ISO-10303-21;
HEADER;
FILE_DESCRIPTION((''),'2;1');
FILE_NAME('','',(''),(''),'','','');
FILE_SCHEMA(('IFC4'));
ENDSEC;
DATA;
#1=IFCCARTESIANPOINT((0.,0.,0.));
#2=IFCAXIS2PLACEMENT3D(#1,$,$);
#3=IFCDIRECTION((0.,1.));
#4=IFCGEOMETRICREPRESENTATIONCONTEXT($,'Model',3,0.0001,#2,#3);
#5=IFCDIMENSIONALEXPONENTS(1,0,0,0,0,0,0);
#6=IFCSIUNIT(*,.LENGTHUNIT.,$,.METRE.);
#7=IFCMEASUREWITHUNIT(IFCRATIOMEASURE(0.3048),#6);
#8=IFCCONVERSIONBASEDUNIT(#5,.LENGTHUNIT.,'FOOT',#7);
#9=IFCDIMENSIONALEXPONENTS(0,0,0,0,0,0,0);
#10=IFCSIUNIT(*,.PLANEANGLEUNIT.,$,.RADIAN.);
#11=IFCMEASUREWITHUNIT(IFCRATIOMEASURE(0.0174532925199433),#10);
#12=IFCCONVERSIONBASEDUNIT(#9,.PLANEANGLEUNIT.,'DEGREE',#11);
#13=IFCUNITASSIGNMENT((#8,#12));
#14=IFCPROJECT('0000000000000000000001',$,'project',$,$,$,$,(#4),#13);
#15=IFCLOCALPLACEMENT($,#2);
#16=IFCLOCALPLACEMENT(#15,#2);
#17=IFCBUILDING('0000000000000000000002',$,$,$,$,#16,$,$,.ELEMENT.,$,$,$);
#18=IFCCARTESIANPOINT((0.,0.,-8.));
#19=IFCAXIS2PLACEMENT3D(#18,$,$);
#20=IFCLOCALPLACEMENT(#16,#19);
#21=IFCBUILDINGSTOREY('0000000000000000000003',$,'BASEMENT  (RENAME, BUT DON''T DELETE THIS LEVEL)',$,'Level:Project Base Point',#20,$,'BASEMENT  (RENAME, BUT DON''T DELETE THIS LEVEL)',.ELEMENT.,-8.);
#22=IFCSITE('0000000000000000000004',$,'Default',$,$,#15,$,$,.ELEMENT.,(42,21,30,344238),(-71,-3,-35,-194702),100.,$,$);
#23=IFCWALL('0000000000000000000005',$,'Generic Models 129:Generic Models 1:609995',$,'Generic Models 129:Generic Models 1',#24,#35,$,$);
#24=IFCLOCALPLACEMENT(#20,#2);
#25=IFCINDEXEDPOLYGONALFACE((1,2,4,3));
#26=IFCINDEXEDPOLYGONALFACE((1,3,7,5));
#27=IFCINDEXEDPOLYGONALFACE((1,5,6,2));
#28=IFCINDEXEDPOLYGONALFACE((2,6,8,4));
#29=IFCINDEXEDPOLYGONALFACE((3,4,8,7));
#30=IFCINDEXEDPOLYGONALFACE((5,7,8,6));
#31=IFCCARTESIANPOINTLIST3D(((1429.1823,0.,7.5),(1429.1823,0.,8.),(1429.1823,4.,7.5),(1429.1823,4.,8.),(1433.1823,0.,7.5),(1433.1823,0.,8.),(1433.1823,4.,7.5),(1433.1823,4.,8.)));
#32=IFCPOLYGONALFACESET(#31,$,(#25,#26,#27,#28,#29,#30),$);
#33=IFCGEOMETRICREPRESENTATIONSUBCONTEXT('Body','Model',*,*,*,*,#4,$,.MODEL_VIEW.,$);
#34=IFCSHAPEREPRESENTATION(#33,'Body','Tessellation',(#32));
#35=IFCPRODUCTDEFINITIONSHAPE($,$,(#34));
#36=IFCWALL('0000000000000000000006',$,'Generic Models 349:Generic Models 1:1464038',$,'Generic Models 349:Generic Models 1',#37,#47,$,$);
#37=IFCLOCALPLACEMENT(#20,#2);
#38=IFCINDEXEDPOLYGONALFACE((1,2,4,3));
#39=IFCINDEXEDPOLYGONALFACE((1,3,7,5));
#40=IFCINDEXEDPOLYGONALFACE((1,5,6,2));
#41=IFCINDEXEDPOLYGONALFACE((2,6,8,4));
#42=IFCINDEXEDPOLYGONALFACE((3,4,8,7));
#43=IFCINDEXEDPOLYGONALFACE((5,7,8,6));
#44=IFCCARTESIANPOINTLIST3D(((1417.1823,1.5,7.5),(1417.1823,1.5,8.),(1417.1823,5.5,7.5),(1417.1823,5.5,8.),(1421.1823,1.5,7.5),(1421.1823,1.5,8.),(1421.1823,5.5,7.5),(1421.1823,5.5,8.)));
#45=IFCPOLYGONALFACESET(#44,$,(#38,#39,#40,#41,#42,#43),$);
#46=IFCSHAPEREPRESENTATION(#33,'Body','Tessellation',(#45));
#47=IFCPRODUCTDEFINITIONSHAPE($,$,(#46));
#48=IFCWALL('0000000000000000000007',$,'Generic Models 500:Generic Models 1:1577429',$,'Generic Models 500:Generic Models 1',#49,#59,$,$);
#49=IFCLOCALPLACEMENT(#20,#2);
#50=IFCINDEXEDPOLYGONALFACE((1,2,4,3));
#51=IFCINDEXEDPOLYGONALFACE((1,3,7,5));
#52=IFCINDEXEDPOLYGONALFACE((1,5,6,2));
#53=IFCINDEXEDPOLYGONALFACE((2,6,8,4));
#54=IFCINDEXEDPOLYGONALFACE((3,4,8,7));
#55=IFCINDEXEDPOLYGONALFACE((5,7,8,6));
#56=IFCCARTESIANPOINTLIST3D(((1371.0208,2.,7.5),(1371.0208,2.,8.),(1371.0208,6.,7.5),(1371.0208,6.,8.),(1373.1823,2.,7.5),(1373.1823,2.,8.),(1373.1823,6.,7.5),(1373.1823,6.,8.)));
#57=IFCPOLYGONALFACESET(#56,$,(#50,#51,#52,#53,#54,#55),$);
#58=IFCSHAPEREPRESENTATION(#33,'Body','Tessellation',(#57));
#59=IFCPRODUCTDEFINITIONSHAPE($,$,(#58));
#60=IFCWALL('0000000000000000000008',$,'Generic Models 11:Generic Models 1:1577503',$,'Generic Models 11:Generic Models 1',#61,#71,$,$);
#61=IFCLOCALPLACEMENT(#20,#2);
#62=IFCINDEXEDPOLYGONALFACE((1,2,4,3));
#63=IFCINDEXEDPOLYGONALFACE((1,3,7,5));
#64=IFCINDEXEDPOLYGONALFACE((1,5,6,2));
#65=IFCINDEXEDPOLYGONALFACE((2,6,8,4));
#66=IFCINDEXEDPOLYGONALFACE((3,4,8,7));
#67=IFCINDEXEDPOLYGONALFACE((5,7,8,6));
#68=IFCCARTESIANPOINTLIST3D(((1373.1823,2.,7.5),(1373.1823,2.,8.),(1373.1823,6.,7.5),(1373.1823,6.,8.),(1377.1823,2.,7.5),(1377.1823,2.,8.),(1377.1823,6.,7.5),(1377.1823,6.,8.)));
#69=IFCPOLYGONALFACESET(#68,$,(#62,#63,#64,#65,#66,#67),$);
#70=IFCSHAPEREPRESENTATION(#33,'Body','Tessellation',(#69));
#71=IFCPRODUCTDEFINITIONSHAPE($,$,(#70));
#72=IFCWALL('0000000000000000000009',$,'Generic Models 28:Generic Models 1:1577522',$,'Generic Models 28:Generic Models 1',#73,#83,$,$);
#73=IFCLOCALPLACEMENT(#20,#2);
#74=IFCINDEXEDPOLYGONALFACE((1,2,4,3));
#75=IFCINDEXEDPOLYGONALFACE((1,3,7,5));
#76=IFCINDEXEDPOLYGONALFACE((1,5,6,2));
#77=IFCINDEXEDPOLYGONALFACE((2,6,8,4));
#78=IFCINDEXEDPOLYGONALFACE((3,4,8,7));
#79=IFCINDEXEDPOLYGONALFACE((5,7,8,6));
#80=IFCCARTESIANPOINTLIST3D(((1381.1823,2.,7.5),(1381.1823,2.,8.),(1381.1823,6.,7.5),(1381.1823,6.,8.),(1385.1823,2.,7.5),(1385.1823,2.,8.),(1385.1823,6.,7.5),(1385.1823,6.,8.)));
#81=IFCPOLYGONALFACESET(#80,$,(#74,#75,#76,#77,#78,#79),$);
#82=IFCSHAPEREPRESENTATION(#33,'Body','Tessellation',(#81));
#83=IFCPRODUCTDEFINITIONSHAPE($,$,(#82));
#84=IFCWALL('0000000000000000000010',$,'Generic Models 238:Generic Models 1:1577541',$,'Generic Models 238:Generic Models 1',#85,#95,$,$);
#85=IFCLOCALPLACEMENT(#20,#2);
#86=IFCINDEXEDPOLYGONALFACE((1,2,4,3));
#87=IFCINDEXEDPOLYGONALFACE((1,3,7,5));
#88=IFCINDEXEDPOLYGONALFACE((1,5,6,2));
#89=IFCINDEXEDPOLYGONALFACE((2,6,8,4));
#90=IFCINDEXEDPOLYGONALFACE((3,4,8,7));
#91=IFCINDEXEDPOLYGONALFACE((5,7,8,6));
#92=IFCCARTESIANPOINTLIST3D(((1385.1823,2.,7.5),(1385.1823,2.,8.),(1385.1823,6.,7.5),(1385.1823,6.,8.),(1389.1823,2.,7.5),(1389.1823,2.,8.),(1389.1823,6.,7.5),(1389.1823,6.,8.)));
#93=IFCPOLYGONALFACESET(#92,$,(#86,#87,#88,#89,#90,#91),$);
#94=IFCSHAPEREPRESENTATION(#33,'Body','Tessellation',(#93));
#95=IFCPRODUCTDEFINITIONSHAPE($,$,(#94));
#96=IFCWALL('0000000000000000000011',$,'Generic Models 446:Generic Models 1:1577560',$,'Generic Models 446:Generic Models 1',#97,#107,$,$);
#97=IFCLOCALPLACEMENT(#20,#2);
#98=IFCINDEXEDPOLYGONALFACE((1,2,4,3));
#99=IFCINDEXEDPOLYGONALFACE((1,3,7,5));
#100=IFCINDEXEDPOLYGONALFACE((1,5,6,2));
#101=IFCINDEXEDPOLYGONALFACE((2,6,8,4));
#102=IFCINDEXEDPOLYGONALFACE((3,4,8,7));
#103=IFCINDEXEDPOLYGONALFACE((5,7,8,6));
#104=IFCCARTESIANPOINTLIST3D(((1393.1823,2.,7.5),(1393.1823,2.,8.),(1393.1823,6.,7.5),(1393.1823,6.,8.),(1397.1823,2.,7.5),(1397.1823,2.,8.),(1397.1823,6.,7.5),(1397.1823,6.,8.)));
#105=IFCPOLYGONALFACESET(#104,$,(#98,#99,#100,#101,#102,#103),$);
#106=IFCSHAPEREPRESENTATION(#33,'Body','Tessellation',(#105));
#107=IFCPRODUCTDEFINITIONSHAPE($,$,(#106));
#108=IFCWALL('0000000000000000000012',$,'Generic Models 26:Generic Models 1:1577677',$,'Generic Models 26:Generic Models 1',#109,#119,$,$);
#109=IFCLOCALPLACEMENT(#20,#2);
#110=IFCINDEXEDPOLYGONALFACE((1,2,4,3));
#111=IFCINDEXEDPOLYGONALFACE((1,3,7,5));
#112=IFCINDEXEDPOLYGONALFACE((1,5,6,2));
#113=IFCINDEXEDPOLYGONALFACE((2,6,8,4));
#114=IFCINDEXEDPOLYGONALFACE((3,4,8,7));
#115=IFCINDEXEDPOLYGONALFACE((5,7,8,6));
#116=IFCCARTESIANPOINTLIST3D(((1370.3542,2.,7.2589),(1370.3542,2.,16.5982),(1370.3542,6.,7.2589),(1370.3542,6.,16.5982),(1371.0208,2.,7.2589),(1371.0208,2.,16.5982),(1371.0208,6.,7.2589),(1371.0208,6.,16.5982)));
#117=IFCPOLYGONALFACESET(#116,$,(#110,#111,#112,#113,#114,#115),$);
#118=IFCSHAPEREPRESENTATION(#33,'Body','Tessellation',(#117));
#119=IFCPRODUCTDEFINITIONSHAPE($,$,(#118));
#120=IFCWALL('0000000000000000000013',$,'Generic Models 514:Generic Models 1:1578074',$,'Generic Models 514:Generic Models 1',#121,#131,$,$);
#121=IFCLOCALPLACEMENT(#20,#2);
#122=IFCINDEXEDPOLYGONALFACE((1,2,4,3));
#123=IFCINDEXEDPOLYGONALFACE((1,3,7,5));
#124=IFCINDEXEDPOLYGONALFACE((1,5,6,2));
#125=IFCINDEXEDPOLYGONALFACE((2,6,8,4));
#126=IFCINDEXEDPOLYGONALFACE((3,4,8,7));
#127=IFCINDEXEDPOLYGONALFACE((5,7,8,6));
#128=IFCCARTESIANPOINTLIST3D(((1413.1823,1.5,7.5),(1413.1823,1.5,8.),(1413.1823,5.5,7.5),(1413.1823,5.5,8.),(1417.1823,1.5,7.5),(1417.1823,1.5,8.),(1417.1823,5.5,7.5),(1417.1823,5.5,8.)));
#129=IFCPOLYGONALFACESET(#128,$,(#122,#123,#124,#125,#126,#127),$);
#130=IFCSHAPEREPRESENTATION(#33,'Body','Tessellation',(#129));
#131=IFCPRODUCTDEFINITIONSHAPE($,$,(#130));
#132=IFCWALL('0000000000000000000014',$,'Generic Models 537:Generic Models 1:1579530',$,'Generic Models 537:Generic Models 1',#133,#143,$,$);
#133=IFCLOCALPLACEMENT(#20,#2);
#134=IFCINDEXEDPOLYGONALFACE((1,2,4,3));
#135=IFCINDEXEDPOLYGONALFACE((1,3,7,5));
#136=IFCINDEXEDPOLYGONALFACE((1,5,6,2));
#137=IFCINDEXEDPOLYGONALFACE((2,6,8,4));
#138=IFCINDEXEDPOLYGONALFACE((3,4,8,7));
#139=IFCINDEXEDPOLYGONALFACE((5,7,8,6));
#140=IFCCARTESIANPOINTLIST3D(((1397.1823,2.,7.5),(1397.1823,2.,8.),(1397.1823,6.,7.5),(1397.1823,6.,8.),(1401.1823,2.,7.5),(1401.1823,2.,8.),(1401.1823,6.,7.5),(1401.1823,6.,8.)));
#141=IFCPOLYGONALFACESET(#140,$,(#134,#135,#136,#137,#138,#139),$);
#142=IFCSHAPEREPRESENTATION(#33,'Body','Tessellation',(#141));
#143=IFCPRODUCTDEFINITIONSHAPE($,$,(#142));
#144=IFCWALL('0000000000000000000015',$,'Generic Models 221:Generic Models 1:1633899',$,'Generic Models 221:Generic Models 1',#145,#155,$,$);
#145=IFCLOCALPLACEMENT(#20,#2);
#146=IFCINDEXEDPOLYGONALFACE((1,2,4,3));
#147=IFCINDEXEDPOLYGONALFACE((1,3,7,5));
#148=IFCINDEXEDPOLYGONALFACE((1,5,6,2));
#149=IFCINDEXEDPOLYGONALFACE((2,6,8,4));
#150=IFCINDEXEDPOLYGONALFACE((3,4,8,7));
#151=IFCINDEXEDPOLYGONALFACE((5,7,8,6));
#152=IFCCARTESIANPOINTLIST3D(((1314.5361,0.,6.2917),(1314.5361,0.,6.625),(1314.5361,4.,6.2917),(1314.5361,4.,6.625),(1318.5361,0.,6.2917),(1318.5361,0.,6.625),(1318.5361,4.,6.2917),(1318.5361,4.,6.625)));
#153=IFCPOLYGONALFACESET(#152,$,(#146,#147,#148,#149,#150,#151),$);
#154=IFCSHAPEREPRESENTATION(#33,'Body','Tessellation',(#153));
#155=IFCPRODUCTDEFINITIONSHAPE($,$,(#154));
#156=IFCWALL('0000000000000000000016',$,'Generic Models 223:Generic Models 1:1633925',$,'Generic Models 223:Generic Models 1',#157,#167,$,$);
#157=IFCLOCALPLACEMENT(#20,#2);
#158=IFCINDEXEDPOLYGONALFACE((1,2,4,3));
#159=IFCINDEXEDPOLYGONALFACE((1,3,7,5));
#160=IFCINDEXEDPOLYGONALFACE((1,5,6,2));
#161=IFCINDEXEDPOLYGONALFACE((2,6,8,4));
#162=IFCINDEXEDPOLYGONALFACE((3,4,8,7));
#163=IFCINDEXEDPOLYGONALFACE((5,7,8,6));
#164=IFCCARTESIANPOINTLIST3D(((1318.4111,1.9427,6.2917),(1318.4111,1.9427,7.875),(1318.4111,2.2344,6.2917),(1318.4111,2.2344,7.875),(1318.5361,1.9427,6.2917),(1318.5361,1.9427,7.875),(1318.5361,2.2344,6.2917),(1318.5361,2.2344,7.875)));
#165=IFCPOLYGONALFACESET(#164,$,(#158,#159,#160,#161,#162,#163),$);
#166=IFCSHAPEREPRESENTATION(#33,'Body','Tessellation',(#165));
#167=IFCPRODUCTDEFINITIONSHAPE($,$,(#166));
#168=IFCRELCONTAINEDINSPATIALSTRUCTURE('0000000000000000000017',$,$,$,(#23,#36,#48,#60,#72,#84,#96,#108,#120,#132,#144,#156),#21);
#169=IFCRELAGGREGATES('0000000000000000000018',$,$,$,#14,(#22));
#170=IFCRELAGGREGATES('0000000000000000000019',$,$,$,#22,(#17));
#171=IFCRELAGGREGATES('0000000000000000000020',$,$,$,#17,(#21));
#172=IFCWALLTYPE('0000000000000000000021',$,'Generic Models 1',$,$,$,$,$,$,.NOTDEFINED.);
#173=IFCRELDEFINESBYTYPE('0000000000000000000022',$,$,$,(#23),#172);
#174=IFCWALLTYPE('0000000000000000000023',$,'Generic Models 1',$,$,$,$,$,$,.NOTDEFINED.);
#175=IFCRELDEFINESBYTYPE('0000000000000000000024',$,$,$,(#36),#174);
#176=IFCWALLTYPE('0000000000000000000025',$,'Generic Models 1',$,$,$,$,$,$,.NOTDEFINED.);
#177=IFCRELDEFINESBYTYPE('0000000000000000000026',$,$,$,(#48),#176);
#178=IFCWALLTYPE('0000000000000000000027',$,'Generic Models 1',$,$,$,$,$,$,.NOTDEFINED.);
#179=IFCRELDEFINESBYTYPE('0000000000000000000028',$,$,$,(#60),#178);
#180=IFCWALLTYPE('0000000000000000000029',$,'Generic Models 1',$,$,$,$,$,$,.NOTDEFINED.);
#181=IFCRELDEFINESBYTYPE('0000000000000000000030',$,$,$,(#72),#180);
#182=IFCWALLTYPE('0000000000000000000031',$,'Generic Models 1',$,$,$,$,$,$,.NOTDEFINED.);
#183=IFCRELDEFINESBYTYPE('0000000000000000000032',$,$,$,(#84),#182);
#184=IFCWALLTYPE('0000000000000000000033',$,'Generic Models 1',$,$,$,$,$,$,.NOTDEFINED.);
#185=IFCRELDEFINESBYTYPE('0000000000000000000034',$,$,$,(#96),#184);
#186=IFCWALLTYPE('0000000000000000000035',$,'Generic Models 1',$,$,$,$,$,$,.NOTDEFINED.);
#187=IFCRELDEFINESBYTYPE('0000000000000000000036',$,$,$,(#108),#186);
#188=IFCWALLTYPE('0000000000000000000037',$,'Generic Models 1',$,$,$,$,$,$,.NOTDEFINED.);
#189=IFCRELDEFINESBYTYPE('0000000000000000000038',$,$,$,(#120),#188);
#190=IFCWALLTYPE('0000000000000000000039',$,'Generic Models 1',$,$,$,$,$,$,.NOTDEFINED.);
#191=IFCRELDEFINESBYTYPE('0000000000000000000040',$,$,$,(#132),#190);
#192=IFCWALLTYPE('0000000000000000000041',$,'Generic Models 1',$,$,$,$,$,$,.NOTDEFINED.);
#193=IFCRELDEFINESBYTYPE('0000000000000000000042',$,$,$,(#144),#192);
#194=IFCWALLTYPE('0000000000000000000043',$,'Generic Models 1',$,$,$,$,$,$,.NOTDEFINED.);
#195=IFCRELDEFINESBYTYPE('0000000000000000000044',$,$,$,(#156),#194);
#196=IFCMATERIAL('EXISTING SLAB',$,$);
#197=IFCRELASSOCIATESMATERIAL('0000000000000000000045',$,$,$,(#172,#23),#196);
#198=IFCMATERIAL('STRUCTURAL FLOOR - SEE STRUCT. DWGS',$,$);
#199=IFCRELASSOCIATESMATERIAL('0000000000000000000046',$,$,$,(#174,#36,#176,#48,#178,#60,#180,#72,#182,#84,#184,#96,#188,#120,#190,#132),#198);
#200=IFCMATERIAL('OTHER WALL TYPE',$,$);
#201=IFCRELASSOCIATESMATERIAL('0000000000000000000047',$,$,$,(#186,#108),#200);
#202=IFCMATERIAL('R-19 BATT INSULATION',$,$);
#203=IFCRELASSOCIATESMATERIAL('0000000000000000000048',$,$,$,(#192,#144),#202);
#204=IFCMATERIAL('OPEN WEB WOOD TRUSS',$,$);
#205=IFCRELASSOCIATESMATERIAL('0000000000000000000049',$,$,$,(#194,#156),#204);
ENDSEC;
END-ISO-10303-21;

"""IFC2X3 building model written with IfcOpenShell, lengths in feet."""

from ifc_helpers import new_model, entity, si_unit, converted_unit, direction, frame, frame_2d, origin, origin_2d_with_axis, place, context, subcontext, project, spatial, rectangle, extrude, material, type_object, element, save


model = new_model("IFC2X3")

# Units and contexts
model_context = context("Model", 3, precision=0.0001, world=origin(), true_north=direction((0.0, 1.0)))
body_context = subcontext(model_context, "Body", "Model", "MODEL_VIEW")
ifc_project = project(units=[converted_unit("LENGTHUNIT", "FOOT", entity("IfcRatioMeasure", 0.3048), si_unit("LENGTHUNIT", "METRE"), dimensions=[1, 0, 0, 0, 0, 0, 0]), converted_unit("PLANEANGLEUNIT", "DEGREE", entity("IfcRatioMeasure", 0.0174532925199433), si_unit("PLANEANGLEUNIT", "RADIAN"), dimensions=[0, 0, 0, 0, 0, 0, 0])], contexts=[model_context])

# Site, building, storey
site_placement = place(None, origin())
site = spatial("IfcSite", under=ifc_project, at=site_placement, Name="Default", CompositionType="ELEMENT", RefLatitude=(42, 21, 30, 344238), RefLongitude=(-71, -3, -35, -194702), RefElevation=100.0)
building_placement = place(site_placement, origin())
building = spatial("IfcBuilding", under=site, at=building_placement, CompositionType="ELEMENT")
storey_placement = place(building_placement, frame((0.0, 0.0, -8.0)))
storey = spatial("IfcBuildingStorey", under=building, at=storey_placement, Name="BASEMENT  (RENAME, BUT DON'T DELETE THIS LEVEL)", ObjectType="Level:Project Base Point", LongName="BASEMENT  (RENAME, BUT DON'T DELETE THIS LEVEL)", CompositionType="ELEMENT", Elevation=-8.0)

# Walls
ifc_material_1 = material(Name="EXISTING SLAB")
wall_type_1 = type_object("IfcWallType", Name="Generic Models 1", PredefinedType="NOTDEFINED", material=ifc_material_1)
wall_1_placement = place(storey_placement, frame((1429.1823, 0.0, 7.5), z_axis=(0.0, 0.0, 1.0), x_axis=(0.0, 1.0, 0.0)))
element("IfcWall", 1, at=wall_1_placement, inside=storey, type_object=wall_type_1, material=ifc_material_1, Name="Generic Models 129:Generic Models 1:609995", ObjectType="Generic Models 129:Generic Models 1", context=body_context, shape_type="SweptSolid", body=[
    extrude(rectangle(XDim=4.0, YDim=4.0, at=frame_2d((0.0, 0.0), x_axis=(1.0, 0.0))), frame((2.0, -2.0, 0.0)), (0.0, 0.0, 1.0), 0.5),
])
ifc_material_2 = material(Name="STRUCTURAL FLOOR - SEE STRUCT. DWGS")
wall_type_2 = type_object("IfcWallType", Name="Generic Models 1", PredefinedType="NOTDEFINED", material=ifc_material_2)
wall_2_placement = place(storey_placement, frame((1417.1823, 1.5, 7.5), z_axis=(0.0, 0.0, 1.0), x_axis=(0.0, 1.0, 0.0)))
element("IfcWall", 2, at=wall_2_placement, inside=storey, type_object=wall_type_2, material=ifc_material_2, Name="Generic Models 349:Generic Models 1:1464038", ObjectType="Generic Models 349:Generic Models 1", context=body_context, shape_type="SweptSolid", body=[
    extrude(rectangle(XDim=4.0, YDim=4.0, at=frame_2d((0.0, 0.0), x_axis=(1.0, 0.0))), frame((2.0, -2.0, 0.0)), (0.0, 0.0, 1.0), 0.5),
])
wall_type_3 = type_object("IfcWallType", Name="Generic Models 1", PredefinedType="NOTDEFINED", material=ifc_material_2)
wall_3_placement = place(storey_placement, frame((1371.0208, 2.0, 7.5), z_axis=(0.0, 0.0, 1.0), x_axis=(0.0, 1.0, 0.0)))
element("IfcWall", 3, at=wall_3_placement, inside=storey, type_object=wall_type_3, material=ifc_material_2, Name="Generic Models 500:Generic Models 1:1577429", ObjectType="Generic Models 500:Generic Models 1", context=body_context, shape_type="SweptSolid", body=[
    extrude(rectangle(XDim=4.0, YDim=2.1615, at=frame_2d((0.0, 0.0), x_axis=(1.0, 0.0))), frame((2.0, -1.0807, 0.0)), (0.0, 0.0, 1.0), 0.5),
])
wall_type_4 = type_object("IfcWallType", Name="Generic Models 1", PredefinedType="NOTDEFINED", material=ifc_material_2)
wall_4_placement = place(storey_placement, frame((1373.1823, 2.0, 7.5), z_axis=(0.0, 0.0, 1.0), x_axis=(0.0, 1.0, 0.0)))
element("IfcWall", 4, at=wall_4_placement, inside=storey, type_object=wall_type_4, material=ifc_material_2, Name="Generic Models 11:Generic Models 1:1577503", ObjectType="Generic Models 11:Generic Models 1", context=body_context, shape_type="SweptSolid", body=[
    extrude(rectangle(XDim=4.0, YDim=4.0, at=origin_2d_with_axis()), frame((2.0, -2.0, 0.0)), (0.0, 0.0, 1.0), 0.5),
])
wall_type_5 = type_object("IfcWallType", Name="Generic Models 1", PredefinedType="NOTDEFINED", material=ifc_material_2)
wall_5_placement = place(storey_placement, frame((1381.1823, 2.0, 7.5), z_axis=(0.0, 0.0, 1.0), x_axis=(0.0, 1.0, 0.0)))
element("IfcWall", 5, at=wall_5_placement, inside=storey, type_object=wall_type_5, material=ifc_material_2, Name="Generic Models 28:Generic Models 1:1577522", ObjectType="Generic Models 28:Generic Models 1", context=body_context, shape_type="SweptSolid", body=[
    extrude(rectangle(XDim=4.0, YDim=4.0, at=frame_2d((0.0, 0.0), x_axis=(1.0, 0.0))), frame((2.0, -2.0, 0.0)), (0.0, 0.0, 1.0), 0.5),
])
wall_type_6 = type_object("IfcWallType", Name="Generic Models 1", PredefinedType="NOTDEFINED", material=ifc_material_2)
wall_6_placement = place(storey_placement, frame((1385.1823, 2.0, 7.5), z_axis=(0.0, 0.0, 1.0), x_axis=(0.0, 1.0, 0.0)))
element("IfcWall", 6, at=wall_6_placement, inside=storey, type_object=wall_type_6, material=ifc_material_2, Name="Generic Models 238:Generic Models 1:1577541", ObjectType="Generic Models 238:Generic Models 1", context=body_context, shape_type="SweptSolid", body=[
    extrude(rectangle(XDim=4.0, YDim=4.0, at=frame_2d((0.0, 0.0), x_axis=(1.0, 0.0))), frame((2.0, -2.0, 0.0)), (0.0, 0.0, 1.0), 0.5),
])
wall_type_7 = type_object("IfcWallType", Name="Generic Models 1", PredefinedType="NOTDEFINED", material=ifc_material_2)
wall_7_placement = place(storey_placement, frame((1393.1823, 2.0, 7.5), z_axis=(0.0, 0.0, 1.0), x_axis=(0.0, 1.0, 0.0)))
element("IfcWall", 7, at=wall_7_placement, inside=storey, type_object=wall_type_7, material=ifc_material_2, Name="Generic Models 446:Generic Models 1:1577560", ObjectType="Generic Models 446:Generic Models 1", context=body_context, shape_type="SweptSolid", body=[
    extrude(rectangle(XDim=4.0, YDim=4.0, at=origin_2d_with_axis()), frame((2.0, -2.0, 0.0)), (0.0, 0.0, 1.0), 0.5),
])
ifc_material_3 = material(Name="OTHER WALL TYPE")
wall_type_8 = type_object("IfcWallType", Name="Generic Models 1", PredefinedType="NOTDEFINED", material=ifc_material_3)
wall_8_placement = place(storey_placement, frame((1370.3542, 2.0, 7.2589), z_axis=(0.0, 0.0, 1.0), x_axis=(0.0, 1.0, 0.0)))
element("IfcWall", 8, at=wall_8_placement, inside=storey, type_object=wall_type_8, material=ifc_material_3, Name="Generic Models 26:Generic Models 1:1577677", ObjectType="Generic Models 26:Generic Models 1", context=body_context, shape_type="SweptSolid", body=[
    extrude(rectangle(XDim=4.0, YDim=0.6667, at=frame_2d((0.0, 0.0), x_axis=(1.0, 0.0))), frame((2.0, -0.3333, 0.0)), (0.0, 0.0, 1.0), 9.3393),
])
wall_type_9 = type_object("IfcWallType", Name="Generic Models 1", PredefinedType="NOTDEFINED", material=ifc_material_2)
wall_9_placement = place(storey_placement, frame((1413.1823, 1.5, 7.5), z_axis=(0.0, 0.0, 1.0), x_axis=(0.0, 1.0, 0.0)))
element("IfcWall", 9, at=wall_9_placement, inside=storey, type_object=wall_type_9, material=ifc_material_2, Name="Generic Models 514:Generic Models 1:1578074", ObjectType="Generic Models 514:Generic Models 1", context=body_context, shape_type="SweptSolid", body=[
    extrude(rectangle(XDim=4.0, YDim=4.0, at=frame_2d((0.0, 0.0), x_axis=(1.0, 0.0))), frame((2.0, -2.0, 0.0)), (0.0, 0.0, 1.0), 0.5),
])
wall_type_10 = type_object("IfcWallType", Name="Generic Models 1", PredefinedType="NOTDEFINED", material=ifc_material_2)
wall_10_placement = place(storey_placement, frame((1397.1823, 2.0, 7.5), z_axis=(0.0, 0.0, 1.0), x_axis=(0.0, 1.0, 0.0)))
element("IfcWall", 10, at=wall_10_placement, inside=storey, type_object=wall_type_10, material=ifc_material_2, Name="Generic Models 537:Generic Models 1:1579530", ObjectType="Generic Models 537:Generic Models 1", context=body_context, shape_type="SweptSolid", body=[
    extrude(rectangle(XDim=4.0, YDim=4.0, at=origin_2d_with_axis()), frame((2.0, -2.0, 0.0)), (0.0, 0.0, 1.0), 0.5),
])
ifc_material_4 = material(Name="R-19 BATT INSULATION")
wall_type_11 = type_object("IfcWallType", Name="Generic Models 1", PredefinedType="NOTDEFINED", material=ifc_material_4)
wall_11_placement = place(storey_placement, frame((1314.5361, 0.0, 6.2917), z_axis=(0.0, 0.0, 1.0), x_axis=(0.0, 1.0, 0.0)))
element("IfcWall", 11, at=wall_11_placement, inside=storey, type_object=wall_type_11, material=ifc_material_4, Name="Generic Models 221:Generic Models 1:1633899", ObjectType="Generic Models 221:Generic Models 1", context=body_context, shape_type="SweptSolid", body=[
    extrude(rectangle(XDim=4.0, YDim=4.0, at=frame_2d((0.0, 0.0), x_axis=(1.0, 0.0))), frame((2.0, -2.0, 0.0)), (0.0, 0.0, 1.0), 0.3333),
])
ifc_material_5 = material(Name="OPEN WEB WOOD TRUSS")
wall_type_12 = type_object("IfcWallType", Name="Generic Models 1", PredefinedType="NOTDEFINED", material=ifc_material_5)
wall_12_placement = place(storey_placement, frame((1318.4111, 1.9427, 6.2917), z_axis=(0.0, 0.0, 1.0), x_axis=(0.0, 1.0, 0.0)))
element("IfcWall", 12, at=wall_12_placement, inside=storey, type_object=wall_type_12, material=ifc_material_5, Name="Generic Models 223:Generic Models 1:1633925", ObjectType="Generic Models 223:Generic Models 1", context=body_context, shape_type="SweptSolid", body=[
    extrude(rectangle(XDim=0.2917, YDim=0.125, at=frame_2d((0.0, 0.0), x_axis=(1.0, 0.0))), frame((0.1458, -0.0625, 0.0)), (0.0, 0.0, 1.0), 1.5833),
])

save(model, "model.ifc")
